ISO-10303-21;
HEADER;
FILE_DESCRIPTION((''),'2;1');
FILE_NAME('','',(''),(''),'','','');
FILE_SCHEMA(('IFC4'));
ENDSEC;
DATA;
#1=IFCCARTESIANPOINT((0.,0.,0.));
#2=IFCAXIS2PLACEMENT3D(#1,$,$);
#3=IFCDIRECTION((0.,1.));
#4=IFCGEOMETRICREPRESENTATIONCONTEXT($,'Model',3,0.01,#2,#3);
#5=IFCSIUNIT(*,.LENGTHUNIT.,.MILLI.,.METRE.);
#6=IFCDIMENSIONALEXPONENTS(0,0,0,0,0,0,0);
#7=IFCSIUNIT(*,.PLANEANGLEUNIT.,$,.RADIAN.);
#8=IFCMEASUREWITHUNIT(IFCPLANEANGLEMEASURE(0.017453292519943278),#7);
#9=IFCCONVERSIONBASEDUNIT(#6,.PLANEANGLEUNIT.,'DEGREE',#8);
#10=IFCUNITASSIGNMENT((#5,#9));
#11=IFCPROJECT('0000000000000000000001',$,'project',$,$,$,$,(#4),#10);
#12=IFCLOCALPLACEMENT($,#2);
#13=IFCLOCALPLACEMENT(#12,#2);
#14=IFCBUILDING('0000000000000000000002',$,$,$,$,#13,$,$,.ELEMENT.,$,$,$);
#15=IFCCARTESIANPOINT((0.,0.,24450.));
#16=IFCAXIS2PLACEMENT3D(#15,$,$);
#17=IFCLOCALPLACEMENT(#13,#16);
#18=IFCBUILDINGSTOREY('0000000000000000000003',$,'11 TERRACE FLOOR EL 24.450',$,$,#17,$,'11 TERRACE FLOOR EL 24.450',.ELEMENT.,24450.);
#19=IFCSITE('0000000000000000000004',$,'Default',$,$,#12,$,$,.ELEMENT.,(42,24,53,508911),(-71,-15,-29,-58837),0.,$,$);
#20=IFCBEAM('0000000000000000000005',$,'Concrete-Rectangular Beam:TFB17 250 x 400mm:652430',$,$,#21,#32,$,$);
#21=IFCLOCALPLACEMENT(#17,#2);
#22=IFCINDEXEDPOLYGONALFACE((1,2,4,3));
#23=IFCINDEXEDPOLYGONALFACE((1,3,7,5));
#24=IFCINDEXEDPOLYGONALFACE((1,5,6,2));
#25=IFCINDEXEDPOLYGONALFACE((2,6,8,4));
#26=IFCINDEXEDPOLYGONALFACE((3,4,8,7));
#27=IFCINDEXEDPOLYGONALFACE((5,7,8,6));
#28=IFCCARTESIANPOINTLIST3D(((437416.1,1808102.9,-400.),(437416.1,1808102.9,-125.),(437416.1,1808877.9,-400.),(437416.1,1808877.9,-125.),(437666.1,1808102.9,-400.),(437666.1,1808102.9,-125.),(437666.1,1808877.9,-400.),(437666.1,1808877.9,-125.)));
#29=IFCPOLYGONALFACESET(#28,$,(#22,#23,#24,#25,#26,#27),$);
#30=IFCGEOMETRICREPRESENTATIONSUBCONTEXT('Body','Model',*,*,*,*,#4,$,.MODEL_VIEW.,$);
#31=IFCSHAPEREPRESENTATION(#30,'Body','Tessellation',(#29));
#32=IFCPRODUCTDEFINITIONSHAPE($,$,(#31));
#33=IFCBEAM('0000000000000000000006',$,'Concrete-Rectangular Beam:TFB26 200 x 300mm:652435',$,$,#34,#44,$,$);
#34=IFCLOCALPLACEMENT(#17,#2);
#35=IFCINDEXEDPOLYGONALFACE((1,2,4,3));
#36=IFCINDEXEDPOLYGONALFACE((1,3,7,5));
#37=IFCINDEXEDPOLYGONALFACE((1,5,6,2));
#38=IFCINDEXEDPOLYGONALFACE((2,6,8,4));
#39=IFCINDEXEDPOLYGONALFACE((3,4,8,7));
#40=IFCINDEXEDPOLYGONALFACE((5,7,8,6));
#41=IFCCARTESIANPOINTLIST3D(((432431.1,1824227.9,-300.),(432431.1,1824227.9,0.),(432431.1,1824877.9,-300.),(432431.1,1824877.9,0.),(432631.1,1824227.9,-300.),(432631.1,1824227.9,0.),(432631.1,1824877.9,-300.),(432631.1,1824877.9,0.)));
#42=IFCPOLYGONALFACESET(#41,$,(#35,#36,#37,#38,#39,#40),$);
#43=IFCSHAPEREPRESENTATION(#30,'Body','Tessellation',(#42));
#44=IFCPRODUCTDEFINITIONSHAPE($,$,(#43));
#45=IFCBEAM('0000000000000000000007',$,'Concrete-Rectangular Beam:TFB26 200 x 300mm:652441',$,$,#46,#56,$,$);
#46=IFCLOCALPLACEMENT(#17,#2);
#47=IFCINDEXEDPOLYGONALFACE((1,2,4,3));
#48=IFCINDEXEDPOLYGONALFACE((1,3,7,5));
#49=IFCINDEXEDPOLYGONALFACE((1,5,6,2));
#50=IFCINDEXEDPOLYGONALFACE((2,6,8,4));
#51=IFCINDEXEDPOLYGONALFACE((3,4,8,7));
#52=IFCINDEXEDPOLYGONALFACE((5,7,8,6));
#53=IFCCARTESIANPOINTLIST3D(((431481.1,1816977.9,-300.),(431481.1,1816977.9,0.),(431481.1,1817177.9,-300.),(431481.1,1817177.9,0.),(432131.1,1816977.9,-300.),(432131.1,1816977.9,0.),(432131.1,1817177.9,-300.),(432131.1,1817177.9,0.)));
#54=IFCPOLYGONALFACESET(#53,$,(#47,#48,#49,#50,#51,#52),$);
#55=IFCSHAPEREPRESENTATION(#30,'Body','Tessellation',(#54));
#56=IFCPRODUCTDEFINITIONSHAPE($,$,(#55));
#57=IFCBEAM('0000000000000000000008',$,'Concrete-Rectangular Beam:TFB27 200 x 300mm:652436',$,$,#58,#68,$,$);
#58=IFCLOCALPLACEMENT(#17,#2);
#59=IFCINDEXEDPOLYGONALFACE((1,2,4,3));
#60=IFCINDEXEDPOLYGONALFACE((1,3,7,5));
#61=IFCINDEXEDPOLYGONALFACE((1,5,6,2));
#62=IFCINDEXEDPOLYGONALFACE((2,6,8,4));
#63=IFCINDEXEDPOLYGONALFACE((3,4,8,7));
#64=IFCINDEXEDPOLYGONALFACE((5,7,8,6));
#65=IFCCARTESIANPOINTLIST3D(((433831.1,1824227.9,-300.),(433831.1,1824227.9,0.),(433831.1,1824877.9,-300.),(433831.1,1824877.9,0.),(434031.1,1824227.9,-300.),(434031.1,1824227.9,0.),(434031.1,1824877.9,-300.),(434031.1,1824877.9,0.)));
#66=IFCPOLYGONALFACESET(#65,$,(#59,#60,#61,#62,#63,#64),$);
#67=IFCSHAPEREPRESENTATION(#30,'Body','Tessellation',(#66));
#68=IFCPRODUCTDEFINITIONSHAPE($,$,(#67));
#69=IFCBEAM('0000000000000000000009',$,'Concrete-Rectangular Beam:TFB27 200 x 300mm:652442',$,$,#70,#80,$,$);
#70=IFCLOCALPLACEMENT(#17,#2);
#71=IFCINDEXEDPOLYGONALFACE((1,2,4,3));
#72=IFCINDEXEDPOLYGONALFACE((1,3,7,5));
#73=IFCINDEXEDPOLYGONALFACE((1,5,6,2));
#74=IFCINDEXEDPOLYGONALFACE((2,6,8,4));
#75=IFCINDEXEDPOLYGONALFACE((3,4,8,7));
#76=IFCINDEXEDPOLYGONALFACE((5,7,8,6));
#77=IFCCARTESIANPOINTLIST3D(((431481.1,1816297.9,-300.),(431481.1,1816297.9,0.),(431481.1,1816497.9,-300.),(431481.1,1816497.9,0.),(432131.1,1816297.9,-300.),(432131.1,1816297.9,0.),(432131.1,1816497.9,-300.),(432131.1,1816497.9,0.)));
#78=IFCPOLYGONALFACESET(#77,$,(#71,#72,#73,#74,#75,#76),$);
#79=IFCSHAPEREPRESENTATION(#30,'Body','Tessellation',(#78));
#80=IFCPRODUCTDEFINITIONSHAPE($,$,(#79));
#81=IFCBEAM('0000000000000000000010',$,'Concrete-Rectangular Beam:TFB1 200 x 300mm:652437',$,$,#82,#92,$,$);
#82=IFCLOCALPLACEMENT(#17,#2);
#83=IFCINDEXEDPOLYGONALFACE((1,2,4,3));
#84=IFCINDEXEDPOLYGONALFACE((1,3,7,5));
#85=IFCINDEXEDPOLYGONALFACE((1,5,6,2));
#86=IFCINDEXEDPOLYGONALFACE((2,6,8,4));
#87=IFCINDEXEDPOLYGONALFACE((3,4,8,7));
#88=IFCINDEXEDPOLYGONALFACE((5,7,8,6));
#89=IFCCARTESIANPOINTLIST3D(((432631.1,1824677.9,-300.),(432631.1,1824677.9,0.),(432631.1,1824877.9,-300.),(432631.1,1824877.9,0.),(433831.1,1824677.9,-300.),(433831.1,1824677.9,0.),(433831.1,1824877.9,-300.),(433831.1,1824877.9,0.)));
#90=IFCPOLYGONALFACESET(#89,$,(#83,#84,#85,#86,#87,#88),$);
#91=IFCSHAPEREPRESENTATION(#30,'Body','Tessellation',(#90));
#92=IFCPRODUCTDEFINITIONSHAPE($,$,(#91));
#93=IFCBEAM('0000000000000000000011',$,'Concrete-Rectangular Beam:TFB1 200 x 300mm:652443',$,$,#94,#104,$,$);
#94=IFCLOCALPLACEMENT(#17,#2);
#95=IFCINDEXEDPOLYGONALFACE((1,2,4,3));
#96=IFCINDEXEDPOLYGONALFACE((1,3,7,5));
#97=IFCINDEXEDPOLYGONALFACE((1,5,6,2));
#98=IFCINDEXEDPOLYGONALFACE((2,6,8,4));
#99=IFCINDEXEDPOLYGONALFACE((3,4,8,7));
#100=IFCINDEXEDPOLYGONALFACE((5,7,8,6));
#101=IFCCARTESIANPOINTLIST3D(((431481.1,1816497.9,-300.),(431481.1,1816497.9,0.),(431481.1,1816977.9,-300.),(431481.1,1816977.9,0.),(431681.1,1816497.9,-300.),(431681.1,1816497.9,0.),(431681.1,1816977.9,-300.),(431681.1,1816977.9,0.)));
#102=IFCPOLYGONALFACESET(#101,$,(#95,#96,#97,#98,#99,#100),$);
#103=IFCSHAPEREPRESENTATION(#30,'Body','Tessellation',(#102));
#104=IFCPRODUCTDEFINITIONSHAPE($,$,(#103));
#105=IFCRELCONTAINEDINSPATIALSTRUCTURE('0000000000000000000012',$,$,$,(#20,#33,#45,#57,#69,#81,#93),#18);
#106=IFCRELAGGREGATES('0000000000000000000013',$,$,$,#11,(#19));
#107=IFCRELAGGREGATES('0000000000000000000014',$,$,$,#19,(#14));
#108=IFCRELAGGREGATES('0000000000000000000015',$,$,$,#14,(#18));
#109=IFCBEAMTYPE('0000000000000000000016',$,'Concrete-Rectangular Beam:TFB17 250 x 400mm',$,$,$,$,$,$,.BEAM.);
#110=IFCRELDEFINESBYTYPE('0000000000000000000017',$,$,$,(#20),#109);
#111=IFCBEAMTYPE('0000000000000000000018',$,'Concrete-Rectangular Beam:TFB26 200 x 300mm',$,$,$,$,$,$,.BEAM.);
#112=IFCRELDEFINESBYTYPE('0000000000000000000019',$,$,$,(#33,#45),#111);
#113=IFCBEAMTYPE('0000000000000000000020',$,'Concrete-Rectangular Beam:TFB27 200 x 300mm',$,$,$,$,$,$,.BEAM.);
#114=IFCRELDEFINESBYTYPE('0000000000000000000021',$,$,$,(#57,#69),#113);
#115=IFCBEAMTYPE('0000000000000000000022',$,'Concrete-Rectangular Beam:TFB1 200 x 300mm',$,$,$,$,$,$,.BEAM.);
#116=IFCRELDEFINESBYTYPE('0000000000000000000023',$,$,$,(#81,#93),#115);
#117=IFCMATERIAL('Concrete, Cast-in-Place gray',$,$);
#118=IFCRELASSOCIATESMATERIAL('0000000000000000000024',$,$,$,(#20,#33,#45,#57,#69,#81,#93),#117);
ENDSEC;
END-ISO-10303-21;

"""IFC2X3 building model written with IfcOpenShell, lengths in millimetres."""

from ifc_helpers import new_model, entity, si_unit, converted_unit, direction, frame, frame_2d, origin, origin_2d_with_axis, place, context, subcontext, project, spatial, rectangle, extrude, material, type_object, element, save


model = new_model("IFC2X3")

# Units and contexts
model_context = context("Model", 3, precision=0.01, world=origin(), true_north=direction((0.0, 1.0)))
body_context = subcontext(model_context, "Body", "Model", "MODEL_VIEW")
ifc_project = project(units=[si_unit("LENGTHUNIT", "METRE", prefix="MILLI"), converted_unit("PLANEANGLEUNIT", "DEGREE", entity("IfcPlaneAngleMeasure", 0.017453292519943278), si_unit("PLANEANGLEUNIT", "RADIAN"), dimensions=[0, 0, 0, 0, 0, 0, 0])], contexts=[model_context])

# Site, building, storey
site_placement = place(None, origin())
site = spatial("IfcSite", under=ifc_project, at=site_placement, Name="Default", CompositionType="ELEMENT", RefLatitude=(42, 24, 53, 508911), RefLongitude=(-71, -15, -29, -58837), RefElevation=0.0)
building_placement = place(site_placement, origin())
building = spatial("IfcBuilding", under=site, at=building_placement, CompositionType="ELEMENT")
storey_placement = place(building_placement, frame((0.0, 0.0, 24450.0)))
storey = spatial("IfcBuildingStorey", under=building, at=storey_placement, Name="11 TERRACE FLOOR EL 24.450", LongName="11 TERRACE FLOOR EL 24.450", CompositionType="ELEMENT", Elevation=24450.0)

# Beams
ifc_material = material(Name="Concrete, Cast-in-Place gray")
beam_type_1 = type_object("IfcBeamType", Name="Concrete-Rectangular Beam:TFB17 250 x 400mm", PredefinedType="BEAM")
beam_1_placement = place(storey_placement, frame((437416.1, 1808877.9, 0.0), z_axis=(0.0, 0.0, 1.0), x_axis=(0.0, -1.0, 0.0)))
element("IfcBeam", 1, at=beam_1_placement, inside=storey, type_object=beam_type_1, material=ifc_material, Name="Concrete-Rectangular Beam:TFB17 250 x 400mm:652430", context=body_context, shape_type="SweptSolid", body=[
    extrude(rectangle(XDim=275.0, YDim=250.0, at=frame_2d((0.0, 0.0), x_axis=(1.0, 0.0))), frame((0.0, 125.0, -262.5), z_axis=(1.0, 0.0, 0.0), x_axis=(0.0, 0.0, -1.0)), (0.0, 0.0, 1.0), 775.0),
])
beam_type_2 = type_object("IfcBeamType", Name="Concrete-Rectangular Beam:TFB26 200 x 300mm", PredefinedType="BEAM")
beam_2_placement = place(storey_placement, frame((432431.1, 1824877.9, 0.0), z_axis=(0.0, 0.0, 1.0), x_axis=(0.0, -1.0, 0.0)))
element("IfcBeam", 2, at=beam_2_placement, inside=storey, type_object=beam_type_2, material=ifc_material, Name="Concrete-Rectangular Beam:TFB26 200 x 300mm:652435", context=body_context, shape_type="SweptSolid", body=[
    extrude(rectangle(XDim=300.0, YDim=200.0, at=origin_2d_with_axis()), frame((0.0, 100.0, -150.0), z_axis=(1.0, 0.0, 0.0), x_axis=(0.0, 0.0, -1.0)), (0.0, 0.0, 1.0), 650.0),
])
beam_3_placement = place(storey_placement, frame((431681.1, 1816977.9, 0.0)))
element("IfcBeam", 3, at=beam_3_placement, inside=storey, type_object=beam_type_2, material=ifc_material, Name="Concrete-Rectangular Beam:TFB26 200 x 300mm:652441", context=body_context, shape_type="SweptSolid", body=[
    extrude(rectangle(XDim=300.0, YDim=200.0, at=origin_2d_with_axis()), frame((-200.0, 100.0, -150.0), z_axis=(1.0, 0.0, 0.0), x_axis=(0.0, 0.0, -1.0)), (0.0, 0.0, 1.0), 650.0),
])
beam_type_3 = type_object("IfcBeamType", Name="Concrete-Rectangular Beam:TFB27 200 x 300mm", PredefinedType="BEAM")
beam_4_placement = place(storey_placement, frame((434031.1, 1824877.9, 0.0), z_axis=(0.0, 0.0, 1.0), x_axis=(0.0, -1.0, 0.0)))
element("IfcBeam", 4, at=beam_4_placement, inside=storey, type_object=beam_type_3, material=ifc_material, Name="Concrete-Rectangular Beam:TFB27 200 x 300mm:652436", context=body_context, shape_type="SweptSolid", body=[
    extrude(rectangle(XDim=300.0, YDim=200.0, at=origin_2d_with_axis()), frame((0.0, -100.0, -150.0), z_axis=(1.0, 0.0, 0.0), x_axis=(0.0, 0.0, -1.0)), (0.0, 0.0, 1.0), 650.0),
])
beam_5_placement = place(storey_placement, frame((431681.1, 1816497.9, 0.0)))
element("IfcBeam", 5, at=beam_5_placement, inside=storey, type_object=beam_type_3, material=ifc_material, Name="Concrete-Rectangular Beam:TFB27 200 x 300mm:652442", context=body_context, shape_type="SweptSolid", body=[
    extrude(rectangle(XDim=300.0, YDim=200.0, at=origin_2d_with_axis()), frame((-200.0, -100.0, -150.0), z_axis=(1.0, 0.0, 0.0), x_axis=(0.0, 0.0, -1.0)), (0.0, 0.0, 1.0), 650.0),
])
beam_type_4 = type_object("IfcBeamType", Name="Concrete-Rectangular Beam:TFB1 200 x 300mm", PredefinedType="BEAM")
beam_6_placement = place(storey_placement, frame((432431.1, 1824877.9, 0.0)))
element("IfcBeam", 6, at=beam_6_placement, inside=storey, type_object=beam_type_4, material=ifc_material, Name="Concrete-Rectangular Beam:TFB1 200 x 300mm:652437", context=body_context, shape_type="SweptSolid", body=[
    extrude(rectangle(XDim=300.0, YDim=200.0, at=origin_2d_with_axis()), frame((200.0, -100.0, -150.0), z_axis=(1.0, 0.0, 0.0), x_axis=(0.0, 0.0, -1.0)), (0.0, 0.0, 1.0), 1200.0),
])
beam_7_placement = place(storey_placement, frame((431681.1, 1816977.9, 0.0), z_axis=(0.0, 0.0, 1.0), x_axis=(0.0, -1.0, 0.0)))
element("IfcBeam", 7, at=beam_7_placement, inside=storey, type_object=beam_type_4, material=ifc_material, Name="Concrete-Rectangular Beam:TFB1 200 x 300mm:652443", context=body_context, shape_type="SweptSolid", body=[
    extrude(rectangle(XDim=300.0, YDim=200.0, at=origin_2d_with_axis()), frame((0.0, -100.0, -150.0), z_axis=(1.0, 0.0, 0.0), x_axis=(0.0, 0.0, -1.0)), (0.0, 0.0, 1.0), 480.0),
])

save(model, "model.ifc")
